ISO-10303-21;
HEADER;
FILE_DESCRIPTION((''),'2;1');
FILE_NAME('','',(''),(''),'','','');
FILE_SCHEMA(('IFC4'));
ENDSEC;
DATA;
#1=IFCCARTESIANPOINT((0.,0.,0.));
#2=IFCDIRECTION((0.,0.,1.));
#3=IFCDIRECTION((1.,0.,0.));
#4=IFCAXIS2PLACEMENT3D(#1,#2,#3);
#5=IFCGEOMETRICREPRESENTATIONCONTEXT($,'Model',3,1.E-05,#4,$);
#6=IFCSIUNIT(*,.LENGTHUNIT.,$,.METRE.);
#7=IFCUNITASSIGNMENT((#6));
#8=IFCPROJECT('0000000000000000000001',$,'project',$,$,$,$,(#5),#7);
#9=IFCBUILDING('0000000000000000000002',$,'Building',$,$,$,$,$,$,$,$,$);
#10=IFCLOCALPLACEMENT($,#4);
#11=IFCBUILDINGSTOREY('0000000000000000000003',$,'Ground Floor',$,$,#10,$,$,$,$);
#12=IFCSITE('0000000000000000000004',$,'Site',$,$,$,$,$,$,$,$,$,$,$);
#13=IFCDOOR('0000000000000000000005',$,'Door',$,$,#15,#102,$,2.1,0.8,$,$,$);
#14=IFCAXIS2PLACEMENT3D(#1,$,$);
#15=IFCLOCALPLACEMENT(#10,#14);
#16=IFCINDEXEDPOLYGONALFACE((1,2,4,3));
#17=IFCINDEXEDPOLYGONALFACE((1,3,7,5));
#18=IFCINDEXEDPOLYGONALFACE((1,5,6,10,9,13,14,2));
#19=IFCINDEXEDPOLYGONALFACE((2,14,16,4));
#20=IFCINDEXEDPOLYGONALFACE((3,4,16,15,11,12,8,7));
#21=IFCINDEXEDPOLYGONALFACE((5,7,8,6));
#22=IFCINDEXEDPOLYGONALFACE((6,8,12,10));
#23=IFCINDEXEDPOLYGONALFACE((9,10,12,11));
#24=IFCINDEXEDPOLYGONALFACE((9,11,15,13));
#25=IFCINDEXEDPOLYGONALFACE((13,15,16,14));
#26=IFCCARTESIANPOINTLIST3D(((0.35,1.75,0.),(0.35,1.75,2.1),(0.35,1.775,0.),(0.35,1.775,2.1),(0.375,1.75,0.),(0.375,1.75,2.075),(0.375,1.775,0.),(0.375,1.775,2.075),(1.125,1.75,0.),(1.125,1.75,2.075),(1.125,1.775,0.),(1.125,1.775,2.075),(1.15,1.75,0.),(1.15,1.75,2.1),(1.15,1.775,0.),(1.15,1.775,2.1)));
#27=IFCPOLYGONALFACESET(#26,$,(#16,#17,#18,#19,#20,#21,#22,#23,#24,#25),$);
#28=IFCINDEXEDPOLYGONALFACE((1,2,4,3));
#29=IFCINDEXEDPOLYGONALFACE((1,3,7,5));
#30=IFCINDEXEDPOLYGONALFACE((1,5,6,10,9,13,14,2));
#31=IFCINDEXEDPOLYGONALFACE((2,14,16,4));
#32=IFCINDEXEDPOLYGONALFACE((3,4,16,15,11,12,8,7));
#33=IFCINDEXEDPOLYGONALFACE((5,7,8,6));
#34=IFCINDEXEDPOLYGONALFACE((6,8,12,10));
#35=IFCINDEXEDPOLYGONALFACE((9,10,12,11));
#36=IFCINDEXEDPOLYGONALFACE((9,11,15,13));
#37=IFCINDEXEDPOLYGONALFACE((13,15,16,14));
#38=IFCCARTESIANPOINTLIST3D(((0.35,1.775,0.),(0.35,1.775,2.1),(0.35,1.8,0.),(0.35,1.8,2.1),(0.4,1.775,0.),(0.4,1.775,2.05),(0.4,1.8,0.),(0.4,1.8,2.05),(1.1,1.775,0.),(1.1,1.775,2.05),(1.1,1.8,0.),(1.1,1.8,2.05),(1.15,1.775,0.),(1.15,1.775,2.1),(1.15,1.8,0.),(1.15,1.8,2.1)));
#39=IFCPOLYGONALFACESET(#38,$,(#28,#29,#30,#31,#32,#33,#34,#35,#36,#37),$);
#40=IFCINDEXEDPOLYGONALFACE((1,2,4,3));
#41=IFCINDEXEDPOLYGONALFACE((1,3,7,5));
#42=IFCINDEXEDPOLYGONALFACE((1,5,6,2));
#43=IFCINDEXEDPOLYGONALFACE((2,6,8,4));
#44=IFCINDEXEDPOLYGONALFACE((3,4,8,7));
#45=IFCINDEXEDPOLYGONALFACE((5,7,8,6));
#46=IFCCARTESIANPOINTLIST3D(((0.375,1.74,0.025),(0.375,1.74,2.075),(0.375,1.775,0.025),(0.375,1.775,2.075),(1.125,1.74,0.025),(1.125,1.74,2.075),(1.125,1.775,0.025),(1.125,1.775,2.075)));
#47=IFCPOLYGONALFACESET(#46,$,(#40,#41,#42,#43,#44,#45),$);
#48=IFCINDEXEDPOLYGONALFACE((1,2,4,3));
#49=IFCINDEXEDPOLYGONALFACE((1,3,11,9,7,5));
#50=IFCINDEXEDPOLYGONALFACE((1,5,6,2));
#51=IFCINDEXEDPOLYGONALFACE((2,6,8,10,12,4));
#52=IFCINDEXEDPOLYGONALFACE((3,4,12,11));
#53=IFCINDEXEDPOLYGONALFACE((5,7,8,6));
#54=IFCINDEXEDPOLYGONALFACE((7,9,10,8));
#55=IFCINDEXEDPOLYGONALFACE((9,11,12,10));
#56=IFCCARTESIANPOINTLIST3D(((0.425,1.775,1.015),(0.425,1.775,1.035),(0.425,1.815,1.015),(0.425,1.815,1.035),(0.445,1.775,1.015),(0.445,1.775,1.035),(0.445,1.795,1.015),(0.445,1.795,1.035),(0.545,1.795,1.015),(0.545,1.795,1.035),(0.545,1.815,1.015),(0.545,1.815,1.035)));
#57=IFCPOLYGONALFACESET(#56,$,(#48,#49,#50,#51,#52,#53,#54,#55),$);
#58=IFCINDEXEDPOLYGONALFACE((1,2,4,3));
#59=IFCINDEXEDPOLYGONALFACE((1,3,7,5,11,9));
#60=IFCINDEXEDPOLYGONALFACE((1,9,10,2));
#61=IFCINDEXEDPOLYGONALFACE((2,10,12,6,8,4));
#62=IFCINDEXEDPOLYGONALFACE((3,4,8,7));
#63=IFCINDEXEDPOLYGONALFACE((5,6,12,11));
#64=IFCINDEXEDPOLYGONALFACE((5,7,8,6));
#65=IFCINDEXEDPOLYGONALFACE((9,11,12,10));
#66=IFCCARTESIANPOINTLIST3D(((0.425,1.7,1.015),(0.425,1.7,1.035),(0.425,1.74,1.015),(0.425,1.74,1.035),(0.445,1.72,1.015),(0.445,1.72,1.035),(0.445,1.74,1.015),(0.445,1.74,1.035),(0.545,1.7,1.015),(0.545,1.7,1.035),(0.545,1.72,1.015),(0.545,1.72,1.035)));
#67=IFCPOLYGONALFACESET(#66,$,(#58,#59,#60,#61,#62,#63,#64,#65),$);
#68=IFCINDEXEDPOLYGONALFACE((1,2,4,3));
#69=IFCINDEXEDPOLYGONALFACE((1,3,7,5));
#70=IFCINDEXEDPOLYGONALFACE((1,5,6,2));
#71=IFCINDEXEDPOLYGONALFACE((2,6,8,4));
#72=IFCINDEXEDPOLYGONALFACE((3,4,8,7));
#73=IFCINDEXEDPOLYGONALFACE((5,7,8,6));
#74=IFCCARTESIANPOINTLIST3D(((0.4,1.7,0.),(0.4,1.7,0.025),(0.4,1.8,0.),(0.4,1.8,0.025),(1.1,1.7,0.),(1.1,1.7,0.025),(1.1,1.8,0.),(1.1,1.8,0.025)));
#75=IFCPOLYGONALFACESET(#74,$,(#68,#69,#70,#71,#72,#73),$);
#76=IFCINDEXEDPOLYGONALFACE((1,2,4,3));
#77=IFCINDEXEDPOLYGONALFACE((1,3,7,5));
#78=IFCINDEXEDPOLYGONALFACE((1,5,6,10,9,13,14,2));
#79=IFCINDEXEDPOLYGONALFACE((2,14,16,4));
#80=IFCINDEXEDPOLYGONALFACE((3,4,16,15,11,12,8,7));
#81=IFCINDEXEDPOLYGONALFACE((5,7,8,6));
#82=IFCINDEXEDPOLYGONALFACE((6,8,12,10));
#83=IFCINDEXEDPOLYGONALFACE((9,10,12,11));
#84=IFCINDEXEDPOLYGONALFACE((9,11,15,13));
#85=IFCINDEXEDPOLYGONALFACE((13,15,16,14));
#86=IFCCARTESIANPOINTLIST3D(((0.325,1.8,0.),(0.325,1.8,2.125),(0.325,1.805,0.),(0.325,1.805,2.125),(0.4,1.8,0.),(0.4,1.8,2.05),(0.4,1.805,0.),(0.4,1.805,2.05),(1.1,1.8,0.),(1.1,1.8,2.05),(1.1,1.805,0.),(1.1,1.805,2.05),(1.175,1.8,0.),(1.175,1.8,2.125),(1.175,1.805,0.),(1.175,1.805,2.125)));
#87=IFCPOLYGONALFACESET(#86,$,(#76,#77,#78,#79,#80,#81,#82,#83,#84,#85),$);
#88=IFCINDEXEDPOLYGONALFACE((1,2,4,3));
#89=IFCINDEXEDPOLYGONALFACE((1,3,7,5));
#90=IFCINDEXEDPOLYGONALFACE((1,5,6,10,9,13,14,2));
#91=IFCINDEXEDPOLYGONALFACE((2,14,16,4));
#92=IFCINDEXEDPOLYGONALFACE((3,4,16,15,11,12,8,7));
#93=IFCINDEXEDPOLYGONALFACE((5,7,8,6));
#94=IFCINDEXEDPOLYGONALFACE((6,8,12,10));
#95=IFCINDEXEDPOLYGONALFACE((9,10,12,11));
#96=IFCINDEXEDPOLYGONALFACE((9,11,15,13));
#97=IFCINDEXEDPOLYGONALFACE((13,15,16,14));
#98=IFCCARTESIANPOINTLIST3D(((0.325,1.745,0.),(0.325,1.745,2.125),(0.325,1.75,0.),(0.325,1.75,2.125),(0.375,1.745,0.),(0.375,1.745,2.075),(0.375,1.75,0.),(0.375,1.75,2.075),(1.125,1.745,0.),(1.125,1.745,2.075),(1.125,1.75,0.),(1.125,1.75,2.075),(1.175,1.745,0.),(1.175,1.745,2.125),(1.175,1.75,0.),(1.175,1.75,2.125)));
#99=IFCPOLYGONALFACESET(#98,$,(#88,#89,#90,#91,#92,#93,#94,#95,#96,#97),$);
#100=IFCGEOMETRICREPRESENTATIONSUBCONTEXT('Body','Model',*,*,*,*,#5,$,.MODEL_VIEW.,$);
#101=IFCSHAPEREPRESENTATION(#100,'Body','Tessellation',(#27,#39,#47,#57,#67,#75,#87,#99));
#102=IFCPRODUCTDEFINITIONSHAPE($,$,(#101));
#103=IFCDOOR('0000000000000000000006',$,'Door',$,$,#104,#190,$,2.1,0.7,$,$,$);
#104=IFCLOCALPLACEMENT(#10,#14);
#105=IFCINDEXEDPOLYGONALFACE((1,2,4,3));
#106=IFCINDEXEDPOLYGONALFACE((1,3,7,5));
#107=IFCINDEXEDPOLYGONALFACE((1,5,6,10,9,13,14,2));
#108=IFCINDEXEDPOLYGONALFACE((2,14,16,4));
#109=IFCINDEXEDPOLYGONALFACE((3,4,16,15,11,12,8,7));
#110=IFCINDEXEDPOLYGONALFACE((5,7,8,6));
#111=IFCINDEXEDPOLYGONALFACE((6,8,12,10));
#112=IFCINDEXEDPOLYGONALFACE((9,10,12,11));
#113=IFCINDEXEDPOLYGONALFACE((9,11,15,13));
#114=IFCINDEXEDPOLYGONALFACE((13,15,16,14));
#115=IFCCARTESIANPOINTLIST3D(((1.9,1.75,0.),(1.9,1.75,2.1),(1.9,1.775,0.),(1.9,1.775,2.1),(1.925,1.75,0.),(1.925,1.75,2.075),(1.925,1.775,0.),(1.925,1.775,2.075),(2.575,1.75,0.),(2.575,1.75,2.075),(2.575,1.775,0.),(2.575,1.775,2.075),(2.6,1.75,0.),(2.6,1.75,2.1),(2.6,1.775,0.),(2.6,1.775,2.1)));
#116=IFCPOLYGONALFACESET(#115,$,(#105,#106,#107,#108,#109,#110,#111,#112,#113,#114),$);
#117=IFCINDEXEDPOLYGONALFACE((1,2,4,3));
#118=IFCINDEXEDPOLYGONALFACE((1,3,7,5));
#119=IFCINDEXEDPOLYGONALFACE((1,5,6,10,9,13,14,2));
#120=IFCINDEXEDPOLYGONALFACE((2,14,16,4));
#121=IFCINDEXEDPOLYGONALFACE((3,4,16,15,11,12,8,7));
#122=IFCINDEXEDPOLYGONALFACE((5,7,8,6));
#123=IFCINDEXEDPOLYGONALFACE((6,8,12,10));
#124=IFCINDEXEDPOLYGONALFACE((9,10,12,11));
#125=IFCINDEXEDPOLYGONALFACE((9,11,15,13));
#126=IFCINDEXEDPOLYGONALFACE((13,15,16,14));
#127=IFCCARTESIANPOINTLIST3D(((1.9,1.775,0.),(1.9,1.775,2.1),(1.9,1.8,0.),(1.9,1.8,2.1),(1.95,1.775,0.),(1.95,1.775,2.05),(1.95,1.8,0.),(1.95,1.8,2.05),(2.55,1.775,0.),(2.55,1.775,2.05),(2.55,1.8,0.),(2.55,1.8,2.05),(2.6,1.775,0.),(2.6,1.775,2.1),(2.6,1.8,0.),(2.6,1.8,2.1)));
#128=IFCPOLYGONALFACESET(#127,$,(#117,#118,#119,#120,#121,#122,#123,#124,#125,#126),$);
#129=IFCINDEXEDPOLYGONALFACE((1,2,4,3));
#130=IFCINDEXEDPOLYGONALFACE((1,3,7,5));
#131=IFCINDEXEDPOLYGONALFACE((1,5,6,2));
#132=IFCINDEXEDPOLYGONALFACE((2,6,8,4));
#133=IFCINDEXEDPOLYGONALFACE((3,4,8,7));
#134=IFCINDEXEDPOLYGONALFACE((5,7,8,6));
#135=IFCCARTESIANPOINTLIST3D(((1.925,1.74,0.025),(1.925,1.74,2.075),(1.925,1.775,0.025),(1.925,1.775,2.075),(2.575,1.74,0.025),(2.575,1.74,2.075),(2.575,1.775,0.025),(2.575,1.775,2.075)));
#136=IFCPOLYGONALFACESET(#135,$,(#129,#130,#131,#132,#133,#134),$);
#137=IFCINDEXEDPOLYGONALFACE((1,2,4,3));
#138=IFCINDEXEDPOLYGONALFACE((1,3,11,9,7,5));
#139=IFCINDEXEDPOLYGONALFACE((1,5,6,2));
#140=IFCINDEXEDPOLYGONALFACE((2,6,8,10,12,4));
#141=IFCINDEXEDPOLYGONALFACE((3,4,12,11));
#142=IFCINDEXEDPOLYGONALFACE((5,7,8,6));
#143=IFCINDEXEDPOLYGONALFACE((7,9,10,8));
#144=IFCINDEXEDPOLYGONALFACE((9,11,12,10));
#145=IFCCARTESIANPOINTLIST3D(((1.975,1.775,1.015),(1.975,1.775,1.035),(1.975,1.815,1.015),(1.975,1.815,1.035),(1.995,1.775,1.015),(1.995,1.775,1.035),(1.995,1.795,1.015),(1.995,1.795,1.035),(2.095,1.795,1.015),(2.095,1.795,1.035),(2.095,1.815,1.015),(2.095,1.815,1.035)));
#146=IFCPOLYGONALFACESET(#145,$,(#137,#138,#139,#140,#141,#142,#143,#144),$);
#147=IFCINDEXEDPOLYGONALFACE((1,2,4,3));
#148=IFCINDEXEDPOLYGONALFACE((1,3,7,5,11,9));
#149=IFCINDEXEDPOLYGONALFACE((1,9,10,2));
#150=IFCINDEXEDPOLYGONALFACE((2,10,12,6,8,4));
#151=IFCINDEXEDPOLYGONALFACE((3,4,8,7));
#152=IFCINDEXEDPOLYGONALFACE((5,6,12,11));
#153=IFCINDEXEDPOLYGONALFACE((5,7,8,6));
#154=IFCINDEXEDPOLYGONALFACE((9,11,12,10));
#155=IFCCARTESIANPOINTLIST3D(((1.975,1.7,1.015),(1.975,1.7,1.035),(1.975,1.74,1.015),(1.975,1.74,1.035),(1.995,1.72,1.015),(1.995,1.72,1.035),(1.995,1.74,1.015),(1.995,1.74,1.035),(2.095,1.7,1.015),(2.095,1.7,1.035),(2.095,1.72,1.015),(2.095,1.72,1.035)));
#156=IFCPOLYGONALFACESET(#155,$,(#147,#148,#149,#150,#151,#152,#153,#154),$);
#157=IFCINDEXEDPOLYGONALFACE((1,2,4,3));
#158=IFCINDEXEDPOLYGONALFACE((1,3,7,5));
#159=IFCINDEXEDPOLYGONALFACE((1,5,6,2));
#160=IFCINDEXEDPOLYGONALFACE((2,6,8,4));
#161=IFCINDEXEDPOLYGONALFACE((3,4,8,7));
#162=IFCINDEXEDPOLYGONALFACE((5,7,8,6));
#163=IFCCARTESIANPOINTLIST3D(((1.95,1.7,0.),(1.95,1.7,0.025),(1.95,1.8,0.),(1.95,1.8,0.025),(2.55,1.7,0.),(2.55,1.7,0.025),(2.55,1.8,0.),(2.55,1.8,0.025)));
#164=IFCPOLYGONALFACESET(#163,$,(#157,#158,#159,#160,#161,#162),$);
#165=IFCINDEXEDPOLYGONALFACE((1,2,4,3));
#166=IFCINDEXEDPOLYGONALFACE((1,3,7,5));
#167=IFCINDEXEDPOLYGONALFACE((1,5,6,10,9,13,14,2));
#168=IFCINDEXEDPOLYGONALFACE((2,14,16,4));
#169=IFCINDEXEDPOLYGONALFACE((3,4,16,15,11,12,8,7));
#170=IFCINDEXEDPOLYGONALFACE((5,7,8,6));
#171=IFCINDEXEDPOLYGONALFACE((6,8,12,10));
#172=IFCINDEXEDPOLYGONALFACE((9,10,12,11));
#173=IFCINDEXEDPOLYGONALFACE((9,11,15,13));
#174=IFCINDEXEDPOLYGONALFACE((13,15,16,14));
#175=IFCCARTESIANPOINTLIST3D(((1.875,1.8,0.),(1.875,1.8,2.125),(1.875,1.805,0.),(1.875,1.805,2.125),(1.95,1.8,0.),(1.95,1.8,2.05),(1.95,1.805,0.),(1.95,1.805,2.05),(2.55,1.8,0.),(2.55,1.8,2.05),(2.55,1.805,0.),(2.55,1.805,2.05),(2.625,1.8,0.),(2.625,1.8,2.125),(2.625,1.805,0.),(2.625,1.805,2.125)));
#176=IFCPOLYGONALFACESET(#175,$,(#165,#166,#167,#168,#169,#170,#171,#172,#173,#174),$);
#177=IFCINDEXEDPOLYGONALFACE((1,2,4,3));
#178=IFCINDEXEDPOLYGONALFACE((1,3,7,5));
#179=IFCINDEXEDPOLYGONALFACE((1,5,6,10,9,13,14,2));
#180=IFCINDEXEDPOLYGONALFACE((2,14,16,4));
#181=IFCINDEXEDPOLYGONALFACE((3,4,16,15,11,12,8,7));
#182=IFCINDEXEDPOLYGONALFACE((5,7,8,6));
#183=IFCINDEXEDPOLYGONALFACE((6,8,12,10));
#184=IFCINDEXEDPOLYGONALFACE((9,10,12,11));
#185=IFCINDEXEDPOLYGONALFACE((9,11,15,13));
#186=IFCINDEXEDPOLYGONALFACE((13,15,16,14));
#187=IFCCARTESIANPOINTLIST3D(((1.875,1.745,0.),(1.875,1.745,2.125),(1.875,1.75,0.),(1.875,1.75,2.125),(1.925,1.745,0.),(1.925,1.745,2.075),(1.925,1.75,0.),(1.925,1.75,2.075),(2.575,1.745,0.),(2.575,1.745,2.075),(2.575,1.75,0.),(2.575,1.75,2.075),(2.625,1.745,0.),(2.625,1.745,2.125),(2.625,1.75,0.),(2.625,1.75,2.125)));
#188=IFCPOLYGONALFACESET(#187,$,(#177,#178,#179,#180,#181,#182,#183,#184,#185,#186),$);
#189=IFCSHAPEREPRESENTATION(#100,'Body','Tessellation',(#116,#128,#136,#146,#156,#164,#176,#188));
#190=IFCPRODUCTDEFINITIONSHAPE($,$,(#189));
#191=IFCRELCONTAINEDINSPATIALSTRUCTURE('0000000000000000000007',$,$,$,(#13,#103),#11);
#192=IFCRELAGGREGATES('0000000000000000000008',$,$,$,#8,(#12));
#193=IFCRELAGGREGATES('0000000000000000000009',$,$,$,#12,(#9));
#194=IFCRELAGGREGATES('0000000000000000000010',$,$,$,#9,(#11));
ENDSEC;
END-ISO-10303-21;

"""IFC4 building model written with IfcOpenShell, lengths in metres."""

from ifc_helpers import new_model, si_unit, frame, origin_with_axes, place, context, subcontext, project, spatial, line, indexed_curve, outline, extrude, element, save


model = new_model("IFC4")

# Units and contexts
model_context = context("Model", 3, precision=1e-05, world=origin_with_axes())
body_context = subcontext(model_context, "Body", "Model", "MODEL_VIEW")
ifc_project = project(units=[si_unit("LENGTHUNIT", "METRE")], contexts=[model_context])

# Site, building, storey
site = spatial("IfcSite", under=ifc_project, Name="Site")
building = spatial("IfcBuilding", under=site, Name="Building")
storey_placement = place(None, origin_with_axes())
storey = spatial("IfcBuildingStorey", under=building, at=storey_placement, Name="Ground Floor")

# Doors
door_1_placement = place(storey_placement, frame((1.15, 1.8, 0.0), z_axis=(0.0, 0.0, 1.0), x_axis=(-1.0, 0.0, 0.0)))
element("IfcDoor", 1, at=door_1_placement, inside=storey, Name="Door", OverallHeight=2.1, OverallWidth=0.8, context=body_context, shape_type="SweptSolid", body=[
    extrude(outline(indexed_curve([(0.0, 0.0), (0.0, 2.1), (0.8, 2.1), (0.8, 0.0), (0.775, 0.0), (0.775, 2.075), (0.025, 2.075), (0.025, 0.0)], segments=[line(1, 2, 3, 4, 5, 6, 7, 8, 1)])), frame((0.0, 0.025, 0.0), z_axis=(0.0, -1.0, 0.0), x_axis=(1.0, 0.0, 0.0)), (0.0, 0.0, -1.0), 0.025),
    extrude(outline(indexed_curve([(0.0, 0.0), (0.0, 2.1), (0.8, 2.1), (0.8, 0.0), (0.75, 0.0), (0.75, 2.05), (0.05, 2.05), (0.05, 0.0)], segments=[line(1, 2, 3, 4, 5, 6, 7, 8, 1)])), frame((0.0, 0.0, 0.0), z_axis=(0.0, -1.0, 0.0), x_axis=(1.0, 0.0, 0.0)), (0.0, 0.0, -1.0), 0.025),
    extrude(outline(indexed_curve([(0.0, 0.0), (0.75, 0.0), (0.75, 0.035), (0.0, 0.035)], segments=[line(1, 2, 3, 4, 1)])), frame((0.025, 0.025, 0.025), z_axis=(0.0, 0.0, 1.0), x_axis=(1.0, 0.0, 0.0)), (0.0, 0.0, 1.0), 2.05),
    extrude(outline(indexed_curve([(0.0, 0.0), (0.0, -0.04), (-0.12, -0.04), (-0.12, -0.02), (-0.02, -0.02), (-0.02, 0.0)], segments=[line(1, 2, 3, 4, 5, 6, 1)])), frame((0.725, 0.025, 1.015), z_axis=(0.0, 0.0, 1.0), x_axis=(1.0, 0.0, 0.0)), (0.0, 0.0, 1.0), 0.02),
    extrude(outline(indexed_curve([(0.0, 0.0), (0.0, 0.04), (-0.12, 0.04), (-0.12, 0.02), (-0.02, 0.02), (-0.02, 0.0)], segments=[line(1, 2, 3, 4, 5, 6, 1)])), frame((0.725, 0.06, 1.015), z_axis=(0.0, 0.0, 1.0), x_axis=(1.0, 0.0, 0.0)), (0.0, 0.0, 1.0), 0.02),
    extrude(outline(indexed_curve([(0.0, 0.0), (0.7, 0.0), (0.7, 0.1), (0.0, 0.1)], segments=[line(1, 2, 3, 4, 1)])), frame((0.05, 0.0, 0.0), z_axis=(0.0, 0.0, 1.0), x_axis=(1.0, 0.0, 0.0)), (0.0, 0.0, 1.0), 0.025),
    extrude(outline(indexed_curve([(0.0, 0.0), (0.0, 2.125), (0.85, 2.125), (0.85, 0.0), (0.775, 0.0), (0.775, 2.05), (0.075, 2.05), (0.075, 0.0)], segments=[line(1, 2, 3, 4, 5, 6, 7, 8, 1)])), frame((-0.025, -0.005, 0.0), z_axis=(0.0, -1.0, 0.0), x_axis=(1.0, 0.0, 0.0)), (0.0, 0.0, -1.0), 0.005),
    extrude(outline(indexed_curve([(0.0, 0.0), (0.0, 2.125), (0.85, 2.125), (0.85, 0.0), (0.8, 0.0), (0.8, 2.075), (0.05, 2.075), (0.05, 0.0)], segments=[line(1, 2, 3, 4, 5, 6, 7, 8, 1)])), frame((-0.025, 0.05, 0.0), z_axis=(0.0, -1.0, 0.0), x_axis=(1.0, 0.0, 0.0)), (0.0, 0.0, -1.0), 0.005),
])
door_2_placement = place(storey_placement, frame((2.6, 1.8, 0.0), z_axis=(0.0, 0.0, 1.0), x_axis=(-1.0, 0.0, 0.0)))
element("IfcDoor", 2, at=door_2_placement, inside=storey, Name="Door", OverallHeight=2.1, OverallWidth=0.7, context=body_context, shape_type="SweptSolid", body=[
    extrude(outline(indexed_curve([(0.0, 0.0), (0.0, 2.1), (0.7, 2.1), (0.7, 0.0), (0.675, 0.0), (0.675, 2.075), (0.025, 2.075), (0.025, 0.0)], segments=[line(1, 2, 3, 4, 5, 6, 7, 8, 1)])), frame((0.0, 0.025, 0.0), z_axis=(0.0, -1.0, 0.0), x_axis=(1.0, 0.0, 0.0)), (0.0, 0.0, -1.0), 0.025),
    extrude(outline(indexed_curve([(0.0, 0.0), (0.0, 2.1), (0.7, 2.1), (0.7, 0.0), (0.65, 0.0), (0.65, 2.05), (0.05, 2.05), (0.05, 0.0)], segments=[line(1, 2, 3, 4, 5, 6, 7, 8, 1)])), frame((0.0, 0.0, 0.0), z_axis=(0.0, -1.0, 0.0), x_axis=(1.0, 0.0, 0.0)), (0.0, 0.0, -1.0), 0.025),
    extrude(outline(indexed_curve([(0.0, 0.0), (0.65, 0.0), (0.65, 0.035), (0.0, 0.035)], segments=[line(1, 2, 3, 4, 1)])), frame((0.025, 0.025, 0.025), z_axis=(0.0, 0.0, 1.0), x_axis=(1.0, 0.0, 0.0)), (0.0, 0.0, 1.0), 2.05),
    extrude(outline(indexed_curve([(0.0, 0.0), (0.0, -0.04), (-0.12, -0.04), (-0.12, -0.02), (-0.02, -0.02), (-0.02, 0.0)], segments=[line(1, 2, 3, 4, 5, 6, 1)])), frame((0.625, 0.025, 1.015), z_axis=(0.0, 0.0, 1.0), x_axis=(1.0, 0.0, 0.0)), (0.0, 0.0, 1.0), 0.02),
    extrude(outline(indexed_curve([(0.0, 0.0), (0.0, 0.04), (-0.12, 0.04), (-0.12, 0.02), (-0.02, 0.02), (-0.02, 0.0)], segments=[line(1, 2, 3, 4, 5, 6, 1)])), frame((0.625, 0.06, 1.015), z_axis=(0.0, 0.0, 1.0), x_axis=(1.0, 0.0, 0.0)), (0.0, 0.0, 1.0), 0.02),
    extrude(outline(indexed_curve([(0.0, 0.0), (0.6, 0.0), (0.6, 0.1), (0.0, 0.1)], segments=[line(1, 2, 3, 4, 1)])), frame((0.05, 0.0, 0.0), z_axis=(0.0, 0.0, 1.0), x_axis=(1.0, 0.0, 0.0)), (0.0, 0.0, 1.0), 0.025),
    extrude(outline(indexed_curve([(0.0, 0.0), (0.0, 2.125), (0.75, 2.125), (0.75, 0.0), (0.675, 0.0), (0.675, 2.05), (0.075, 2.05), (0.075, 0.0)], segments=[line(1, 2, 3, 4, 5, 6, 7, 8, 1)])), frame((-0.025, -0.005, 0.0), z_axis=(0.0, -1.0, 0.0), x_axis=(1.0, 0.0, 0.0)), (0.0, 0.0, -1.0), 0.005),
    extrude(outline(indexed_curve([(0.0, 0.0), (0.0, 2.125), (0.75, 2.125), (0.75, 0.0), (0.7, 0.0), (0.7, 2.075), (0.05, 2.075), (0.05, 0.0)], segments=[line(1, 2, 3, 4, 5, 6, 7, 8, 1)])), frame((-0.025, 0.05, 0.0), z_axis=(0.0, -1.0, 0.0), x_axis=(1.0, 0.0, 0.0)), (0.0, 0.0, -1.0), 0.005),
])

save(model, "model.ifc")
